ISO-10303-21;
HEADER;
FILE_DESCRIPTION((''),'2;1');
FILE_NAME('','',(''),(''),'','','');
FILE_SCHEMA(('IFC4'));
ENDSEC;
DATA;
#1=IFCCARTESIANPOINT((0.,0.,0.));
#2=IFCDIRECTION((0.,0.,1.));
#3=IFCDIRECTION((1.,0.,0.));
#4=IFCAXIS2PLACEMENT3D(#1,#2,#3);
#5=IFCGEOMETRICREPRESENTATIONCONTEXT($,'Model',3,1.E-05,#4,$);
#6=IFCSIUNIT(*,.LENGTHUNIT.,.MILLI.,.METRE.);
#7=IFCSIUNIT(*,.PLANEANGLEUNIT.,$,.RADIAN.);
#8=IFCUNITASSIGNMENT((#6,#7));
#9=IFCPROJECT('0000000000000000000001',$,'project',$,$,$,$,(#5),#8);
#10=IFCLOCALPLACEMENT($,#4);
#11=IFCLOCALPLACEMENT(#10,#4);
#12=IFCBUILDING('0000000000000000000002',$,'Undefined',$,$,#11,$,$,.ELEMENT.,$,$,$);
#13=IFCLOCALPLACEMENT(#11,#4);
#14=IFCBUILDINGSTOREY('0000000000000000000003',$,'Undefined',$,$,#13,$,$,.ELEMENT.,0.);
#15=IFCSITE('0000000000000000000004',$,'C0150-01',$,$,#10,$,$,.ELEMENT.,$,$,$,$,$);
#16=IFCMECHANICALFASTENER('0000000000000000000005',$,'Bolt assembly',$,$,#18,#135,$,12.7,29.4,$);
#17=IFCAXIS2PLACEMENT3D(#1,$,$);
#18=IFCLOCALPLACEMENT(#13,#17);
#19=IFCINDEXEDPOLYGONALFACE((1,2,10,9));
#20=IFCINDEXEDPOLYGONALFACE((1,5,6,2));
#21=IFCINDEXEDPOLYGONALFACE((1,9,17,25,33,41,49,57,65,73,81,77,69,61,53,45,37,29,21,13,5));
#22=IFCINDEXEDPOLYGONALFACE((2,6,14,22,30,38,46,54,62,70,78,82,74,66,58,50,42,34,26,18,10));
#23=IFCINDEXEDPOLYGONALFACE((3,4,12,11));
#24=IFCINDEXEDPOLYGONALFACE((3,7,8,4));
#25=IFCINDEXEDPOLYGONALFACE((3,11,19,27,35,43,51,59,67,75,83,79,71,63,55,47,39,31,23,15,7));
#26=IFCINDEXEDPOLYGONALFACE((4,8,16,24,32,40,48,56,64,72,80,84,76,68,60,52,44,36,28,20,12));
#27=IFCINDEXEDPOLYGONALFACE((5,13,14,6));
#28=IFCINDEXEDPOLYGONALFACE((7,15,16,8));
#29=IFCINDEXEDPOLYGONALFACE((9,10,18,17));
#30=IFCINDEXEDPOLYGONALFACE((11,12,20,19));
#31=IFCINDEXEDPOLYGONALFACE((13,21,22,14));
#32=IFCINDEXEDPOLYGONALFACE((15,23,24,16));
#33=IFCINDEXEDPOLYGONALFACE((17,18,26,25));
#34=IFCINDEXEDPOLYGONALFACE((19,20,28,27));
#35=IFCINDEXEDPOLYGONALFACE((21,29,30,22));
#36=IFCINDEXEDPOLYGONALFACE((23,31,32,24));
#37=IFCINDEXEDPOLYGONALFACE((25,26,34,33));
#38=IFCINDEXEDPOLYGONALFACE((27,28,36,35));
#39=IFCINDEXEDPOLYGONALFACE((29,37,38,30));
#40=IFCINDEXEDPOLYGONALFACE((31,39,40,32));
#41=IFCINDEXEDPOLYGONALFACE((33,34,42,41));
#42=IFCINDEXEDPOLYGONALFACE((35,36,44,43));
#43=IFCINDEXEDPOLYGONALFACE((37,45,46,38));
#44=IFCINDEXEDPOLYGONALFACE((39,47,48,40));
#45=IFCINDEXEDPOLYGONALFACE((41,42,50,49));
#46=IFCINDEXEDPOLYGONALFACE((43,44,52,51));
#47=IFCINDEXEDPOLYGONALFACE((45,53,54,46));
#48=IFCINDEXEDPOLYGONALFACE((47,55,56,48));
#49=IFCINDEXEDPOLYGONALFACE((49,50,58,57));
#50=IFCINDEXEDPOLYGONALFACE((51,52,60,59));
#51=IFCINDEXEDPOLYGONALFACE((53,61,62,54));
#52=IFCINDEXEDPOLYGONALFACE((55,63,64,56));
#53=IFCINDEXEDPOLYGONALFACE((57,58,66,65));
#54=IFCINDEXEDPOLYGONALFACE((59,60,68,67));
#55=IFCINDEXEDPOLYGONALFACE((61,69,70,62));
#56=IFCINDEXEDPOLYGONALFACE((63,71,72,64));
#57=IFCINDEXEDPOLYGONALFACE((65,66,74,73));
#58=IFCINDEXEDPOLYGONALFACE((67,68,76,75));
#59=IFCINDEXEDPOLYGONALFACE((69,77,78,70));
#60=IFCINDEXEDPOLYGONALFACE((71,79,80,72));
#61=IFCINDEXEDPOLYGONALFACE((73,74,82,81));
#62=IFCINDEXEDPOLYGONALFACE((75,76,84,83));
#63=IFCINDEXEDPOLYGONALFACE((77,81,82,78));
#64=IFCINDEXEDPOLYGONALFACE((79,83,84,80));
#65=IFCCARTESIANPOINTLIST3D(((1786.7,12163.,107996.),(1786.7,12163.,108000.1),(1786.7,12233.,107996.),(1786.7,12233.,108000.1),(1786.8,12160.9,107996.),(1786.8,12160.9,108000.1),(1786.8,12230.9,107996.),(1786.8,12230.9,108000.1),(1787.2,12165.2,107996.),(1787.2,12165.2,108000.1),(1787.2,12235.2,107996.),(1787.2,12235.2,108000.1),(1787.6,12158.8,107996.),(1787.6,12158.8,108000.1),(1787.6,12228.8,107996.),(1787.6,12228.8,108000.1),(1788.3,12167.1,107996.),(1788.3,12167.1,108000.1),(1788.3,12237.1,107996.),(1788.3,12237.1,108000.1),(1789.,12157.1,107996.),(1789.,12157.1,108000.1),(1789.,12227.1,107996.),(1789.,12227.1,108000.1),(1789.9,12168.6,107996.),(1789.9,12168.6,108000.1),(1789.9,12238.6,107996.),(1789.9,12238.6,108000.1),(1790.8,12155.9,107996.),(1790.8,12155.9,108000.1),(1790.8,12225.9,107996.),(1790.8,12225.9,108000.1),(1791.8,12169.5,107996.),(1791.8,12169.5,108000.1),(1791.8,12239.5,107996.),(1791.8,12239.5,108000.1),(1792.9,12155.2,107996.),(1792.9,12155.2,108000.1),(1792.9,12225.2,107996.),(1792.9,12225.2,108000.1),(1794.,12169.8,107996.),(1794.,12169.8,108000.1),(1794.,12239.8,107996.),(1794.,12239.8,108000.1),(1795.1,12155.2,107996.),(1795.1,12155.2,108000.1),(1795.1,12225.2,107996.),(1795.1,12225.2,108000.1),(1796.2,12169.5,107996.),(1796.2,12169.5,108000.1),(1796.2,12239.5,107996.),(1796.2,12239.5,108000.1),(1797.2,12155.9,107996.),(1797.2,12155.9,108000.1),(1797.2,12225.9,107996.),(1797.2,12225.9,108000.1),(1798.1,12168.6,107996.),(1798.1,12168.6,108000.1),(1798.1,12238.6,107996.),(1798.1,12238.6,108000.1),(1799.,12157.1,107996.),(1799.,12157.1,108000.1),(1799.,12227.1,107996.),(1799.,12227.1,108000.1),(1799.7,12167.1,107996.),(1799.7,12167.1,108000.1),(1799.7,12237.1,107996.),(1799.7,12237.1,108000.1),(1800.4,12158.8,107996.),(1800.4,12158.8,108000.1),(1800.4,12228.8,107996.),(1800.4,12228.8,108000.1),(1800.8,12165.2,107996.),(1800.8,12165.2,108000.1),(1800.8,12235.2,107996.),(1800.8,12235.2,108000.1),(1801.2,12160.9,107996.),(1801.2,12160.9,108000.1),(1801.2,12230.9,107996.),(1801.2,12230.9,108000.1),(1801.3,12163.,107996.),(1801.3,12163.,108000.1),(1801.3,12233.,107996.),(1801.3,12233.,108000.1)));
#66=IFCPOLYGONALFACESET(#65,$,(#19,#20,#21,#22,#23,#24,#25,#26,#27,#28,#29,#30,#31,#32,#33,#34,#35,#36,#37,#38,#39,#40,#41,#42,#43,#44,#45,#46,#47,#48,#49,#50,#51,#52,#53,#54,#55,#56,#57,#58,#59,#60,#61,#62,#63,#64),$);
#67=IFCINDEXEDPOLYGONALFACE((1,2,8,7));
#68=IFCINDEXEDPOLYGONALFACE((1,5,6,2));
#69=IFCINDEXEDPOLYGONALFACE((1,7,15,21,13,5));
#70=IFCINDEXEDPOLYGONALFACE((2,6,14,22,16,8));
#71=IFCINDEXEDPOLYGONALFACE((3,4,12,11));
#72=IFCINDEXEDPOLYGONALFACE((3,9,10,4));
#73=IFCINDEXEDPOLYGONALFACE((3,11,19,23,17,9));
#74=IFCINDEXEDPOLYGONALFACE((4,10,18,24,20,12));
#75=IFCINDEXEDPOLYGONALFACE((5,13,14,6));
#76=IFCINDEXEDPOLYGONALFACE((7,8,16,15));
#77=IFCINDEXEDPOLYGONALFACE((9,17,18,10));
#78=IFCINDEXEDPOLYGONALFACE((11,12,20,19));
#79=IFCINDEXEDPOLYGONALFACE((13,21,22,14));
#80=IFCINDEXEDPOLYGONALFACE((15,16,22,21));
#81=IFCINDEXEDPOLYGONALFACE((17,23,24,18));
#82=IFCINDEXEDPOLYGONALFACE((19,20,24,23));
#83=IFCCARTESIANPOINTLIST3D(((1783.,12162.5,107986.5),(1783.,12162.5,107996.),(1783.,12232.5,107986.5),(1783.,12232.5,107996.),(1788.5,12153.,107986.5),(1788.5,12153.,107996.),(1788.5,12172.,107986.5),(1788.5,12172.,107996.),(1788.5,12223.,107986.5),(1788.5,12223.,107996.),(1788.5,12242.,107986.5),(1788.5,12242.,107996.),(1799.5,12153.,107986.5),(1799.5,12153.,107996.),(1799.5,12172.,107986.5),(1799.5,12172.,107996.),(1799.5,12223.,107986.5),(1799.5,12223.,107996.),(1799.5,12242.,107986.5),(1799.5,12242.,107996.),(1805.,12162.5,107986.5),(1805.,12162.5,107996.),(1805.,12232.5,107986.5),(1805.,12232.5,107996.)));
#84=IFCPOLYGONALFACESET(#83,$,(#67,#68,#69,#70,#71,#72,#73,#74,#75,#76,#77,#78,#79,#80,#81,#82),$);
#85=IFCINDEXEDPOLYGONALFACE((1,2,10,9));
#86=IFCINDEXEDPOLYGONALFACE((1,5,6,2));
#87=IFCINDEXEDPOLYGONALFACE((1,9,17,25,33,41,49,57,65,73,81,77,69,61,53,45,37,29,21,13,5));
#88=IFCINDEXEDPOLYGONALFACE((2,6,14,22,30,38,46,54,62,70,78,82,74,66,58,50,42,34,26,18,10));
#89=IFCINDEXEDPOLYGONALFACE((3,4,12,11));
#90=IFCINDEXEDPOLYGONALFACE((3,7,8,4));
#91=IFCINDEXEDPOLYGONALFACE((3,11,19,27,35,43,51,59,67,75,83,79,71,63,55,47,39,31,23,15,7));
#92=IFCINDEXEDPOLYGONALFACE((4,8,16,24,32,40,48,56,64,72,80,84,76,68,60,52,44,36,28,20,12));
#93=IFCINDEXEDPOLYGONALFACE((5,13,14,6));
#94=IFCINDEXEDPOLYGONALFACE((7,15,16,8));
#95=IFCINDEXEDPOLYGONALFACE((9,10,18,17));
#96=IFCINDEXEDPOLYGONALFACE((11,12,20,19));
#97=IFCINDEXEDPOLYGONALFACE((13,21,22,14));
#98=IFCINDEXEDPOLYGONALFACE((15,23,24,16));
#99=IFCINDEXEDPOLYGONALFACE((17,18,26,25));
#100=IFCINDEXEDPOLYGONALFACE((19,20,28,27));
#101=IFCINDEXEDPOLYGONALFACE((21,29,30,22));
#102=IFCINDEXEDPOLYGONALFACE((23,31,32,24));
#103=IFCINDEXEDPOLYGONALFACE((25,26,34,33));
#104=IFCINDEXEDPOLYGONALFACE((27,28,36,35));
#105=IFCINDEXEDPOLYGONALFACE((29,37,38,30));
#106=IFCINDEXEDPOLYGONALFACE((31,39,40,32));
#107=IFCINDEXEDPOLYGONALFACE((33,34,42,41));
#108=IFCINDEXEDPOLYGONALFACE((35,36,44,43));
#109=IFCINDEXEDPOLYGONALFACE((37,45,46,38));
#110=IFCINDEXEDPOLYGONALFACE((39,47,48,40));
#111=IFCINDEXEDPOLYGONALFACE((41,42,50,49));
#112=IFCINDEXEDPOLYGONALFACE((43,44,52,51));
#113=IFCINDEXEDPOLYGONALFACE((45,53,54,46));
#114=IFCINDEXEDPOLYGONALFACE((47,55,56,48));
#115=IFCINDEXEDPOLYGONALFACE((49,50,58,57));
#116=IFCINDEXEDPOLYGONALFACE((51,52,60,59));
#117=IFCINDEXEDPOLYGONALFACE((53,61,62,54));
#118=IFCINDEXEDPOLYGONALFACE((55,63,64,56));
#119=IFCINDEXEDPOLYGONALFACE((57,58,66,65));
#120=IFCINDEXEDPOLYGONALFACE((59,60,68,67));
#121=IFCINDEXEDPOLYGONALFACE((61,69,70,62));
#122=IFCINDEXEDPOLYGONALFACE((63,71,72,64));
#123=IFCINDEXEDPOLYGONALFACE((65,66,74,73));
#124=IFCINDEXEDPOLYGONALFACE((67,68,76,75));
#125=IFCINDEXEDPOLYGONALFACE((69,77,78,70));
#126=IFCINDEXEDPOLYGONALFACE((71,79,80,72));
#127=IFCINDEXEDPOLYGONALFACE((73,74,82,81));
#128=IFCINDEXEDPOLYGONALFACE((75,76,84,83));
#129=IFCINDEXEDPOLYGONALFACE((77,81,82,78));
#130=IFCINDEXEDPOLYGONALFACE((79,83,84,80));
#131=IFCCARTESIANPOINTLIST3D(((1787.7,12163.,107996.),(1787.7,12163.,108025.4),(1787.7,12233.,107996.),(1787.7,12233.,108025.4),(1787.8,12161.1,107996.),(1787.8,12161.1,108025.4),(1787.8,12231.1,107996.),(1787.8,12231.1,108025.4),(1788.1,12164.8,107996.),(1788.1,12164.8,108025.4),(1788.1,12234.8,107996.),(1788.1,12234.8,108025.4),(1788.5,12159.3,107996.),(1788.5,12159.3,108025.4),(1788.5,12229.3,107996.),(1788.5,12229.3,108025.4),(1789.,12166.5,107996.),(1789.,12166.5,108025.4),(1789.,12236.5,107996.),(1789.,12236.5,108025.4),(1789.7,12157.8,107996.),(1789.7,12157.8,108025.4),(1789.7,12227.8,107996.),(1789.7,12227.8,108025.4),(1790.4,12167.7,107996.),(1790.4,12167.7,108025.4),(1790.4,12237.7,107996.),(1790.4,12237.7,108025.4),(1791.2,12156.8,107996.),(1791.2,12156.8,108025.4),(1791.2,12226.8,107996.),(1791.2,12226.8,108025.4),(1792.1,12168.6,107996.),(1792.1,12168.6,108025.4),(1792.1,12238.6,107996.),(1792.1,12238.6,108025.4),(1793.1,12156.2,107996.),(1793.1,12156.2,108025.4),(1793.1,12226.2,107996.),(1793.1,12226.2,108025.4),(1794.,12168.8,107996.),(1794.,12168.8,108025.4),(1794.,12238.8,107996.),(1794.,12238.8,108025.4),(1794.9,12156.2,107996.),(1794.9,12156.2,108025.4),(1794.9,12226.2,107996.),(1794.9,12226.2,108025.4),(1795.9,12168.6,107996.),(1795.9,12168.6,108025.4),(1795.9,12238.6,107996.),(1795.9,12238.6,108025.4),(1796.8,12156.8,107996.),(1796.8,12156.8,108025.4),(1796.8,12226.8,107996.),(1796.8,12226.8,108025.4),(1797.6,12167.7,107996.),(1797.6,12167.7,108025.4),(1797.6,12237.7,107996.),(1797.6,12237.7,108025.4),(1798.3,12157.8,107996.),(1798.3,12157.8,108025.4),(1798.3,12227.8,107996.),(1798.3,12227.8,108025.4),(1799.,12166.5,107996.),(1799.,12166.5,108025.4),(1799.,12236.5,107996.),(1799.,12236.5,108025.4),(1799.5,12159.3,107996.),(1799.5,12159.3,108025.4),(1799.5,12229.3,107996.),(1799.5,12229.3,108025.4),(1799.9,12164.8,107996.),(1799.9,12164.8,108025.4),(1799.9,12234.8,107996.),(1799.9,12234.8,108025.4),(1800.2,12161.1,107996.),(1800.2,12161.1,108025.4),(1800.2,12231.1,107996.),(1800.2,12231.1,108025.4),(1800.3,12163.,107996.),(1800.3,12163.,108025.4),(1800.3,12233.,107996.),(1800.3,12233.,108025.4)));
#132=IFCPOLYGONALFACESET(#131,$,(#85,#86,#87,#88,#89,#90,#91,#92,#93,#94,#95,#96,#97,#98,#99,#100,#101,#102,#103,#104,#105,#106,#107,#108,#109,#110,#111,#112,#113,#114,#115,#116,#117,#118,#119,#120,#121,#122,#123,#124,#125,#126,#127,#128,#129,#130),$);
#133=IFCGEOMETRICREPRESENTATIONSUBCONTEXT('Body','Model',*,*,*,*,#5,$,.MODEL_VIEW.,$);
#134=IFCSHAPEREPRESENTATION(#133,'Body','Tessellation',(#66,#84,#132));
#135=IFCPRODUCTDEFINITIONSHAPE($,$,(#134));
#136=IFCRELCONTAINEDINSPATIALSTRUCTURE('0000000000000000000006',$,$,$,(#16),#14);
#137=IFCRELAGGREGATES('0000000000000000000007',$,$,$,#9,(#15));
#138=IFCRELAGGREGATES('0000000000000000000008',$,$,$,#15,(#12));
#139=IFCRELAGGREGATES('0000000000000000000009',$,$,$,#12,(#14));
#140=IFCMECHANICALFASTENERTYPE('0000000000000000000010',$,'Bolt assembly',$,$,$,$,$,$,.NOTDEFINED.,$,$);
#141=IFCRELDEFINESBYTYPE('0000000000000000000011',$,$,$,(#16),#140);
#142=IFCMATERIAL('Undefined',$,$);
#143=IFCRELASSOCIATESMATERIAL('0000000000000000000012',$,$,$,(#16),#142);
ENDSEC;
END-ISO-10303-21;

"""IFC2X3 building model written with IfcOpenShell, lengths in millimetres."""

from ifc_helpers import new_model, si_unit, frame, origin_with_axes, origin_2d_with_axis, place, context, subcontext, project, spatial, polyline, circle, outline, extrude, source, transform, mapped, material, type_object, element, save


model = new_model("IFC2X3")

# Units and contexts
model_context = context("Model", 3, precision=1e-05, world=origin_with_axes())
body_context = subcontext(model_context, "Body", "Model", "MODEL_VIEW")
ifc_project = project(units=[si_unit("LENGTHUNIT", "METRE", prefix="MILLI"), si_unit("PLANEANGLEUNIT", "RADIAN")], contexts=[model_context])

# Site, building, storey
site_placement = place(None, origin_with_axes())
site = spatial("IfcSite", under=ifc_project, at=site_placement, Name="C0150-01", CompositionType="ELEMENT")
building_placement = place(site_placement, origin_with_axes())
building = spatial("IfcBuilding", under=site, at=building_placement, Name="Undefined", CompositionType="ELEMENT")
storey_placement = place(building_placement, origin_with_axes())
storey = spatial("IfcBuildingStorey", under=building, at=storey_placement, Name="Undefined", CompositionType="ELEMENT", Elevation=0.0)

# Mechanical fastener
ifc_material_1 = material(Name="Undefined")
mechanical_fastener_type = type_object("IfcMechanicalFastenerType", Name="Bolt assembly")
shared_shape_1 = source(origin_with_axes(), body_context, "Body", "SweptSolid", [
    extrude(circle(Radius=7.3, at=origin_2d_with_axis()), frame((0.0, 0.0, 0.0), z_axis=(0.0, 1.0, 0.0), x_axis=(1.0, 0.0, 0.0)), (0.0, 0.0, 1.0), 4.1),
    extrude(outline(polyline([(9.5, -5.5), (9.5, 5.5), (0.0, 11.0), (-9.5, 5.5), (-9.5, -5.5), (0.0, -11.0), (9.5, -5.5)])), frame((0.0, -9.5, 0.0), z_axis=(0.0, 1.0, 0.0), x_axis=(1.0, 0.0, 0.0)), (0.0, 0.0, 1.0), 9.5),
    extrude(circle(Radius=6.3, at=origin_2d_with_axis()), frame((0.0, 0.0, 0.0), z_axis=(0.0, 1.0, 0.0), x_axis=(1.0, 0.0, 0.0)), (0.0, 0.0, 1.0), 29.4),
])
for number, where, z_axis, x_axis, name in (
    (1, (1794.0, 12162.5, 107996.0), (1.0, 0.0, 0.0), (0.0, 1.0, 0.0), "Bolt assembly"),
):
    element("IfcMechanicalFastener", number, at=place(storey_placement, frame(where, z_axis=z_axis, x_axis=x_axis)), inside=storey, type_object=mechanical_fastener_type, material=ifc_material_1, Name=name, NominalDiameter=12.7, NominalLength=29.4, context=body_context, shape_type="MappedRepresentation", body=[
        mapped(shared_shape_1, transform((0.0, 0.0, 0.0))),
        mapped(shared_shape_1, transform((70.0, 0.0, 0.0))),
    ])

save(model, "model.ifc")
